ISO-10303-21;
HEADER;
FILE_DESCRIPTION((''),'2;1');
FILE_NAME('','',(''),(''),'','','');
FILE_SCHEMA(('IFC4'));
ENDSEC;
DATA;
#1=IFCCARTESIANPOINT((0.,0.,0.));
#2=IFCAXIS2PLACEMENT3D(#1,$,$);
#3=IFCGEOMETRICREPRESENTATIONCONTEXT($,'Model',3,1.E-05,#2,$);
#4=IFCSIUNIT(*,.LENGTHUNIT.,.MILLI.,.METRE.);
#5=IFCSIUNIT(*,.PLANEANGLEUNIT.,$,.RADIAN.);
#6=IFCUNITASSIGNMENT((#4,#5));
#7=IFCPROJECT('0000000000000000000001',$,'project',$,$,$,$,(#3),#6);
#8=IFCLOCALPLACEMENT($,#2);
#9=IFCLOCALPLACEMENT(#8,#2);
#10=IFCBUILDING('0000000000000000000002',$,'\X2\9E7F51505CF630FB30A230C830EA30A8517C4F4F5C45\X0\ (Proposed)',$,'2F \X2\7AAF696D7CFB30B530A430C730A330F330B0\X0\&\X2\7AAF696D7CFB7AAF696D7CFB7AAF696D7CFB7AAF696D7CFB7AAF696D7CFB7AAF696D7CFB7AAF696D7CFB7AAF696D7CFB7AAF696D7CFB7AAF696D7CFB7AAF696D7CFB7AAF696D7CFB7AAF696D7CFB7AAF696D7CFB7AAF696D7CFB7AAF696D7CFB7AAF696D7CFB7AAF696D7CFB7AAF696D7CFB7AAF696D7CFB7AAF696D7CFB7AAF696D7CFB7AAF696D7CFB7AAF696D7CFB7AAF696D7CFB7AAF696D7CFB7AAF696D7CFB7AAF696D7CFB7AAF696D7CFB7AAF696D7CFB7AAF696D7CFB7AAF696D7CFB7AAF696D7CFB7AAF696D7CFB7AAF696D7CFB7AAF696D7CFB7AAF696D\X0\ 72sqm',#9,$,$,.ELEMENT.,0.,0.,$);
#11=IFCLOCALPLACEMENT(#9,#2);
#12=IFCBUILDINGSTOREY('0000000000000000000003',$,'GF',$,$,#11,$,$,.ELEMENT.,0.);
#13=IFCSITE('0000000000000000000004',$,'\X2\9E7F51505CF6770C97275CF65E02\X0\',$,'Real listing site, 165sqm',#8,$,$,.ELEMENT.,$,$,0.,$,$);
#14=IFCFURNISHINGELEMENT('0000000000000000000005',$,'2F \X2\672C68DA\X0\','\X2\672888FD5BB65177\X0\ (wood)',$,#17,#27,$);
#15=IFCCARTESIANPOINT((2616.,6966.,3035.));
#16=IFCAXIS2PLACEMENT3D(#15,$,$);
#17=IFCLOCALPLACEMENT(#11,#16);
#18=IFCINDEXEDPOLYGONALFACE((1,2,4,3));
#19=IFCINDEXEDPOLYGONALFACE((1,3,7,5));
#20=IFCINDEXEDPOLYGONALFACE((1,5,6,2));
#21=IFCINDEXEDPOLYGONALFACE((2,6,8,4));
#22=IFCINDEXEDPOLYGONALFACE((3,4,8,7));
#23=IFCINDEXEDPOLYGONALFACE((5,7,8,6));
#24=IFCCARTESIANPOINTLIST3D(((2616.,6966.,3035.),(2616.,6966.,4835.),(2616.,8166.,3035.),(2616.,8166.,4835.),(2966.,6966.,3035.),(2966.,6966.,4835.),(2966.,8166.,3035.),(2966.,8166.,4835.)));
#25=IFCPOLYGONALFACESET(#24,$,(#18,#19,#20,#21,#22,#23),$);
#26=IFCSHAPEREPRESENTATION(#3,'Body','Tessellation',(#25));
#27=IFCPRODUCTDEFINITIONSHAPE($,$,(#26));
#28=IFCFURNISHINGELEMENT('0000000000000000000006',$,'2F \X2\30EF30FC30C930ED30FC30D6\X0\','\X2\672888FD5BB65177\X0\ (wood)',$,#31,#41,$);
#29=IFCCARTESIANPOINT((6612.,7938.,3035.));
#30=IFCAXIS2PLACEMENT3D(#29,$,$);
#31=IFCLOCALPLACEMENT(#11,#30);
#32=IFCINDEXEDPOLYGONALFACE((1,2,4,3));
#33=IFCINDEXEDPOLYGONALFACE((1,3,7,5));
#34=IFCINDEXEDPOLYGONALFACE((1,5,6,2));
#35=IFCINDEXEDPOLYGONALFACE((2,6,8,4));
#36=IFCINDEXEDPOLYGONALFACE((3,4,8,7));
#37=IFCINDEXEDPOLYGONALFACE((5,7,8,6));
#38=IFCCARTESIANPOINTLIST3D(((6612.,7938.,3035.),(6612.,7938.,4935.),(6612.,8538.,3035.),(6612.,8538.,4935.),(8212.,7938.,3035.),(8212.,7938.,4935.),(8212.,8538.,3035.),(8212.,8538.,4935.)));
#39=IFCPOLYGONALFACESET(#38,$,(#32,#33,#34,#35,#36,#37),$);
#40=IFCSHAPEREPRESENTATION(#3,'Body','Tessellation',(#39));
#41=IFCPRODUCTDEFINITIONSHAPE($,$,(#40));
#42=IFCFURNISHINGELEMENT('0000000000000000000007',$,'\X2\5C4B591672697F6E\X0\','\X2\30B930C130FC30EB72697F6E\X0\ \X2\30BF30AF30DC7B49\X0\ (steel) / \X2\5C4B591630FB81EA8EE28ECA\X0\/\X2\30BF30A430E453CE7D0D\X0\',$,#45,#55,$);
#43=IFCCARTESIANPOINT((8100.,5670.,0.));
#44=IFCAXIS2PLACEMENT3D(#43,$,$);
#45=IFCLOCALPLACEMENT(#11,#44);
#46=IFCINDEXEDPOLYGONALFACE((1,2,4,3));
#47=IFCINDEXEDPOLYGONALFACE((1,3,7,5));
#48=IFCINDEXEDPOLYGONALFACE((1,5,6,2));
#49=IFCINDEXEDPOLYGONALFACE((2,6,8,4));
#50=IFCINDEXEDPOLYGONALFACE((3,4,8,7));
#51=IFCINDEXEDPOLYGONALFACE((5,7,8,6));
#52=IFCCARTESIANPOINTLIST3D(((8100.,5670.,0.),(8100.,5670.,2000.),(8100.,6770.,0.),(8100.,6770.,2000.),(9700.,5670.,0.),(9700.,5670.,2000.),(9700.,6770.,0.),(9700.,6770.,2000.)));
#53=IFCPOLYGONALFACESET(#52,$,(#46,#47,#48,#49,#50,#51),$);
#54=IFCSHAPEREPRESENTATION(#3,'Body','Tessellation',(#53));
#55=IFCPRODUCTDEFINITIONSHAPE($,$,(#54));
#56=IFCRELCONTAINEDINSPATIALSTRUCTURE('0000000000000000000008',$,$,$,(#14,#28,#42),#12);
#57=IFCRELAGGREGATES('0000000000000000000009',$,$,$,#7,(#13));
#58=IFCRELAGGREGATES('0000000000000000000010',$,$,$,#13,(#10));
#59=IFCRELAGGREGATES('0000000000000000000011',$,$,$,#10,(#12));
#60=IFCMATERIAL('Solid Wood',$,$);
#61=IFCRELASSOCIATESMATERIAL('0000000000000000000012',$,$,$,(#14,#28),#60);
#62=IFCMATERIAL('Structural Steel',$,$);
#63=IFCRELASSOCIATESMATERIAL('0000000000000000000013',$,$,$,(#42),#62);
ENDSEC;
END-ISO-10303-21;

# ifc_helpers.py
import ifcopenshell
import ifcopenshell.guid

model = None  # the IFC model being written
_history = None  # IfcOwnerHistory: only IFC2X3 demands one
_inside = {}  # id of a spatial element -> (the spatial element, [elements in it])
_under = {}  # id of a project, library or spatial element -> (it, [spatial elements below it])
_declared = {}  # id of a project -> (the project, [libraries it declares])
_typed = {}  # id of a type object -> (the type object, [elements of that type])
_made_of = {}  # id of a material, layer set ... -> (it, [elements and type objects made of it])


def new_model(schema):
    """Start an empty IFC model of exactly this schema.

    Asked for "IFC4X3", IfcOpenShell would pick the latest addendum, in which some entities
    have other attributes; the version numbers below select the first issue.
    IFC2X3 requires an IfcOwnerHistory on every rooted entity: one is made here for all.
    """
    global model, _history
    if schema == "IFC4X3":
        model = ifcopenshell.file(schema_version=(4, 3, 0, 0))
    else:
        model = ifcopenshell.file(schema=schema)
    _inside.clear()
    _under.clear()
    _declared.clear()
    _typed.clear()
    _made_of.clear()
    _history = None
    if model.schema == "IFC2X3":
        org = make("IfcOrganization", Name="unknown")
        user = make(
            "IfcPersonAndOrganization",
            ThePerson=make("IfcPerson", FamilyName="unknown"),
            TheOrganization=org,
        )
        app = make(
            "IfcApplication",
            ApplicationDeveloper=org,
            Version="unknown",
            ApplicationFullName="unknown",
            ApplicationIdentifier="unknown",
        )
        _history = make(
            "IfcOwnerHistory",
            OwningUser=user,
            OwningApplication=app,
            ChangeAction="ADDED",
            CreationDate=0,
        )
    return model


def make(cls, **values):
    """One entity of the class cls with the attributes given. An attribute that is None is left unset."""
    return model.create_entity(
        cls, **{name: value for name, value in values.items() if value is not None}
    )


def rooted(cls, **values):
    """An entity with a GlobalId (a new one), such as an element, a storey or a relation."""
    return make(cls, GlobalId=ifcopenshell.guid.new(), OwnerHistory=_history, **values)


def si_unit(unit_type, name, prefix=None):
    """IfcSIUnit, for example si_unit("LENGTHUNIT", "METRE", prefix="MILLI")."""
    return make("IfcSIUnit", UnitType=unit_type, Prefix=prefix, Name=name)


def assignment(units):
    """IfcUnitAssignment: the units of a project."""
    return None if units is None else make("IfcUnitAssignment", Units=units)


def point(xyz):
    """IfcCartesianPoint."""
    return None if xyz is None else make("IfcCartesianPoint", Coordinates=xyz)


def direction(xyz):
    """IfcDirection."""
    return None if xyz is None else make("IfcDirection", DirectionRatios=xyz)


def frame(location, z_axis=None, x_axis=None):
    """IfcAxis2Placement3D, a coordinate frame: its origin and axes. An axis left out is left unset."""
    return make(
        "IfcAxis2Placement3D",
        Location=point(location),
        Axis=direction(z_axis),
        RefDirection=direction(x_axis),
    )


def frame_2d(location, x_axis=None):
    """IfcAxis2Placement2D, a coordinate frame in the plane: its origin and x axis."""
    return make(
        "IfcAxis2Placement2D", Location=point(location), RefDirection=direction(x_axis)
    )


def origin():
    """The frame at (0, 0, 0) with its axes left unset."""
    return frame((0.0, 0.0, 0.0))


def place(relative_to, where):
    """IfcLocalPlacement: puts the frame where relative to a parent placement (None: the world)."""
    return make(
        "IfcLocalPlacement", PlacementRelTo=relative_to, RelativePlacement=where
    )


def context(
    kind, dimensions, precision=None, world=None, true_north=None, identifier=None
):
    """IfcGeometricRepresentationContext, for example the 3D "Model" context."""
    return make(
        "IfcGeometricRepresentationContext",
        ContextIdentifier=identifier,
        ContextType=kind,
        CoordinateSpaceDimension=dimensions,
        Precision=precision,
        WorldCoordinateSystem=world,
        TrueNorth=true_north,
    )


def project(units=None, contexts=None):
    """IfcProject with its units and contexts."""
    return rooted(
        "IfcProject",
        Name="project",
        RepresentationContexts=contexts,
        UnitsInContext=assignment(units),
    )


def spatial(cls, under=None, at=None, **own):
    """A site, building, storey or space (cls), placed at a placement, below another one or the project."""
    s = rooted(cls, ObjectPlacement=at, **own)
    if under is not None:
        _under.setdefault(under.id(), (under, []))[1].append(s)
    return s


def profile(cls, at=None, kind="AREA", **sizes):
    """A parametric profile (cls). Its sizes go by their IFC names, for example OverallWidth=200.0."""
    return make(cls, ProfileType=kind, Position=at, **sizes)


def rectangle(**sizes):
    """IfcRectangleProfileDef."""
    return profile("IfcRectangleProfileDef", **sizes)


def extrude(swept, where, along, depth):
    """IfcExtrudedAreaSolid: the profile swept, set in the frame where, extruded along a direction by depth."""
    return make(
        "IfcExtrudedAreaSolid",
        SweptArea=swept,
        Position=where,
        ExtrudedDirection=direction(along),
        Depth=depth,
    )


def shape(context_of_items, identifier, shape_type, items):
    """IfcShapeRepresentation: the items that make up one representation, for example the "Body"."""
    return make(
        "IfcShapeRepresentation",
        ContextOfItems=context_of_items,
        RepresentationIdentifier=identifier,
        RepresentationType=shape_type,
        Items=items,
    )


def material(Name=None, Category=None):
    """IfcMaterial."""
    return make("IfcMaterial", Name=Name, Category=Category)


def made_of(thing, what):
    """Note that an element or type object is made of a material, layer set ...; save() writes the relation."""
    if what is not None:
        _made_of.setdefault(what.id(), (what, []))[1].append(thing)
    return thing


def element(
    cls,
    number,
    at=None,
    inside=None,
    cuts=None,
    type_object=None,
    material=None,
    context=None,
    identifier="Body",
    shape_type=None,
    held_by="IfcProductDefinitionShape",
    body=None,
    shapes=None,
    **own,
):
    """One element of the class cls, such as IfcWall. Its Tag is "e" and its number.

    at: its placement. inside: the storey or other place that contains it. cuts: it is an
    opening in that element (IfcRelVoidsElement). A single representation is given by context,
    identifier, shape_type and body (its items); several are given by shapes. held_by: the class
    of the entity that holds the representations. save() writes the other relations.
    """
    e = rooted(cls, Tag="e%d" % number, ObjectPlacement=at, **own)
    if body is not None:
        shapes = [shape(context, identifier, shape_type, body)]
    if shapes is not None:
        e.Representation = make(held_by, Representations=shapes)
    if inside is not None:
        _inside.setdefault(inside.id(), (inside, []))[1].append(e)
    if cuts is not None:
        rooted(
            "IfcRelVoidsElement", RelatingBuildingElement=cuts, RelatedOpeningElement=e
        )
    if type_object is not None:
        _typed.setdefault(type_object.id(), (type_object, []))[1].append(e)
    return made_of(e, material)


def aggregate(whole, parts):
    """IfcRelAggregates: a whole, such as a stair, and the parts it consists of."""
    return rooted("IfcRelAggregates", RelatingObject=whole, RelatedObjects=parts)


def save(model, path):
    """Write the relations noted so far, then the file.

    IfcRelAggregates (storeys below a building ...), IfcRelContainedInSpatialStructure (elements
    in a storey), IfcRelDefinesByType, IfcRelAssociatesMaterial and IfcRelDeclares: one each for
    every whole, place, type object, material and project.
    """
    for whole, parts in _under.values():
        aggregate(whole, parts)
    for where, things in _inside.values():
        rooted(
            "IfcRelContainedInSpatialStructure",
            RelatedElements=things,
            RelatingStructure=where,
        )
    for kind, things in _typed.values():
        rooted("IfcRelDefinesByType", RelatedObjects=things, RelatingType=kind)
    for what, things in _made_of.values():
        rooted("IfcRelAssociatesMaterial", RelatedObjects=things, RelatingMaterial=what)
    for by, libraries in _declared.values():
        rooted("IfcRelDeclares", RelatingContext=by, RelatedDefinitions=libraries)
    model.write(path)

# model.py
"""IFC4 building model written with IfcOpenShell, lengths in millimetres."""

from ifc_helpers import new_model, si_unit, frame, frame_2d, origin, place, context, project, spatial, rectangle, extrude, material, element, save


model = new_model("IFC4")

# Units and contexts
model_context = context("Model", 3, precision=1e-05, world=origin())
ifc_project = project(units=[si_unit("LENGTHUNIT", "METRE", prefix="MILLI"), si_unit("PLANEANGLEUNIT", "RADIAN")], contexts=[model_context])

# Site, building, storey
site_placement = place(None, origin())
site = spatial("IfcSite", under=ifc_project, at=site_placement, Name="鹿児島県霧島市", ObjectType="Real listing site, 165sqm", CompositionType="ELEMENT", RefElevation=0.0)
building_placement = place(site_placement, origin())
building = spatial("IfcBuilding", under=site, at=building_placement, Name="鹿児島・アトリエ兼住居 (Proposed)", ObjectType="2F 窯業系サイディング&窯業系窯業系窯業系窯業系窯業系窯業系窯業系窯業系窯業系窯業系窯業系窯業系窯業系窯業系窯業系窯業系窯業系窯業系窯業系窯業系窯業系窯業系窯業系窯業系窯業系窯業系窯業系窯業系窯業系窯業系窯業系窯業系窯業系窯業系窯業系窯業系窯業 72sqm", CompositionType="ELEMENT", ElevationOfRefHeight=0.0, ElevationOfTerrain=0.0)
storey_placement = place(building_placement, origin())
storey = spatial("IfcBuildingStorey", under=building, at=storey_placement, Name="GF", CompositionType="ELEMENT", Elevation=0.0)

# Shared definitions
ifc_material_1 = material(Name="Solid Wood")

# Shared definitions
ifc_material_2 = material(Name="Structural Steel")

# Furnishing elements
furnishing_1_placement = place(storey_placement, frame((2616.0, 6966.0, 3035.0)))
element("IfcFurnishingElement", 1, at=furnishing_1_placement, inside=storey, material=ifc_material_1, Name="2F 本棚", Description="木製家具 (wood)", context=model_context, shape_type="SweptSolid", body=[
    extrude(rectangle(XDim=350.0, YDim=1200.0, at=frame_2d((175.0, 600.0))), frame((2616.0, 6966.0, 3035.0)), (0.0, 0.0, 1.0), 1800.0),
])
furnishing_2_placement = place(storey_placement, frame((6612.0, 7938.0, 3035.0)))
element("IfcFurnishingElement", 2, at=furnishing_2_placement, inside=storey, material=ifc_material_1, Name="2F ワードローブ", Description="木製家具 (wood)", context=model_context, shape_type="SweptSolid", body=[
    extrude(rectangle(XDim=1600.0, YDim=600.0, at=frame_2d((800.0, 300.0))), frame((6612.0, 7938.0, 3035.0)), (0.0, 0.0, 1.0), 1900.0),
])
furnishing_3_placement = place(storey_placement, frame((8100.0, 5670.0, 0.0)))
element("IfcFurnishingElement", 3, at=furnishing_3_placement, inside=storey, material=ifc_material_2, Name="屋外物置", Description="スチール物置 タクボ等 (steel) / 屋外・自転車/タイヤ収納", context=model_context, shape_type="SweptSolid", body=[
    extrude(rectangle(XDim=1600.0, YDim=1100.0, at=frame_2d((800.0, 550.0))), frame((8100.0, 5670.0, 0.0)), (0.0, 0.0, 1.0), 2000.0),
])

save(model, "model.ifc")
